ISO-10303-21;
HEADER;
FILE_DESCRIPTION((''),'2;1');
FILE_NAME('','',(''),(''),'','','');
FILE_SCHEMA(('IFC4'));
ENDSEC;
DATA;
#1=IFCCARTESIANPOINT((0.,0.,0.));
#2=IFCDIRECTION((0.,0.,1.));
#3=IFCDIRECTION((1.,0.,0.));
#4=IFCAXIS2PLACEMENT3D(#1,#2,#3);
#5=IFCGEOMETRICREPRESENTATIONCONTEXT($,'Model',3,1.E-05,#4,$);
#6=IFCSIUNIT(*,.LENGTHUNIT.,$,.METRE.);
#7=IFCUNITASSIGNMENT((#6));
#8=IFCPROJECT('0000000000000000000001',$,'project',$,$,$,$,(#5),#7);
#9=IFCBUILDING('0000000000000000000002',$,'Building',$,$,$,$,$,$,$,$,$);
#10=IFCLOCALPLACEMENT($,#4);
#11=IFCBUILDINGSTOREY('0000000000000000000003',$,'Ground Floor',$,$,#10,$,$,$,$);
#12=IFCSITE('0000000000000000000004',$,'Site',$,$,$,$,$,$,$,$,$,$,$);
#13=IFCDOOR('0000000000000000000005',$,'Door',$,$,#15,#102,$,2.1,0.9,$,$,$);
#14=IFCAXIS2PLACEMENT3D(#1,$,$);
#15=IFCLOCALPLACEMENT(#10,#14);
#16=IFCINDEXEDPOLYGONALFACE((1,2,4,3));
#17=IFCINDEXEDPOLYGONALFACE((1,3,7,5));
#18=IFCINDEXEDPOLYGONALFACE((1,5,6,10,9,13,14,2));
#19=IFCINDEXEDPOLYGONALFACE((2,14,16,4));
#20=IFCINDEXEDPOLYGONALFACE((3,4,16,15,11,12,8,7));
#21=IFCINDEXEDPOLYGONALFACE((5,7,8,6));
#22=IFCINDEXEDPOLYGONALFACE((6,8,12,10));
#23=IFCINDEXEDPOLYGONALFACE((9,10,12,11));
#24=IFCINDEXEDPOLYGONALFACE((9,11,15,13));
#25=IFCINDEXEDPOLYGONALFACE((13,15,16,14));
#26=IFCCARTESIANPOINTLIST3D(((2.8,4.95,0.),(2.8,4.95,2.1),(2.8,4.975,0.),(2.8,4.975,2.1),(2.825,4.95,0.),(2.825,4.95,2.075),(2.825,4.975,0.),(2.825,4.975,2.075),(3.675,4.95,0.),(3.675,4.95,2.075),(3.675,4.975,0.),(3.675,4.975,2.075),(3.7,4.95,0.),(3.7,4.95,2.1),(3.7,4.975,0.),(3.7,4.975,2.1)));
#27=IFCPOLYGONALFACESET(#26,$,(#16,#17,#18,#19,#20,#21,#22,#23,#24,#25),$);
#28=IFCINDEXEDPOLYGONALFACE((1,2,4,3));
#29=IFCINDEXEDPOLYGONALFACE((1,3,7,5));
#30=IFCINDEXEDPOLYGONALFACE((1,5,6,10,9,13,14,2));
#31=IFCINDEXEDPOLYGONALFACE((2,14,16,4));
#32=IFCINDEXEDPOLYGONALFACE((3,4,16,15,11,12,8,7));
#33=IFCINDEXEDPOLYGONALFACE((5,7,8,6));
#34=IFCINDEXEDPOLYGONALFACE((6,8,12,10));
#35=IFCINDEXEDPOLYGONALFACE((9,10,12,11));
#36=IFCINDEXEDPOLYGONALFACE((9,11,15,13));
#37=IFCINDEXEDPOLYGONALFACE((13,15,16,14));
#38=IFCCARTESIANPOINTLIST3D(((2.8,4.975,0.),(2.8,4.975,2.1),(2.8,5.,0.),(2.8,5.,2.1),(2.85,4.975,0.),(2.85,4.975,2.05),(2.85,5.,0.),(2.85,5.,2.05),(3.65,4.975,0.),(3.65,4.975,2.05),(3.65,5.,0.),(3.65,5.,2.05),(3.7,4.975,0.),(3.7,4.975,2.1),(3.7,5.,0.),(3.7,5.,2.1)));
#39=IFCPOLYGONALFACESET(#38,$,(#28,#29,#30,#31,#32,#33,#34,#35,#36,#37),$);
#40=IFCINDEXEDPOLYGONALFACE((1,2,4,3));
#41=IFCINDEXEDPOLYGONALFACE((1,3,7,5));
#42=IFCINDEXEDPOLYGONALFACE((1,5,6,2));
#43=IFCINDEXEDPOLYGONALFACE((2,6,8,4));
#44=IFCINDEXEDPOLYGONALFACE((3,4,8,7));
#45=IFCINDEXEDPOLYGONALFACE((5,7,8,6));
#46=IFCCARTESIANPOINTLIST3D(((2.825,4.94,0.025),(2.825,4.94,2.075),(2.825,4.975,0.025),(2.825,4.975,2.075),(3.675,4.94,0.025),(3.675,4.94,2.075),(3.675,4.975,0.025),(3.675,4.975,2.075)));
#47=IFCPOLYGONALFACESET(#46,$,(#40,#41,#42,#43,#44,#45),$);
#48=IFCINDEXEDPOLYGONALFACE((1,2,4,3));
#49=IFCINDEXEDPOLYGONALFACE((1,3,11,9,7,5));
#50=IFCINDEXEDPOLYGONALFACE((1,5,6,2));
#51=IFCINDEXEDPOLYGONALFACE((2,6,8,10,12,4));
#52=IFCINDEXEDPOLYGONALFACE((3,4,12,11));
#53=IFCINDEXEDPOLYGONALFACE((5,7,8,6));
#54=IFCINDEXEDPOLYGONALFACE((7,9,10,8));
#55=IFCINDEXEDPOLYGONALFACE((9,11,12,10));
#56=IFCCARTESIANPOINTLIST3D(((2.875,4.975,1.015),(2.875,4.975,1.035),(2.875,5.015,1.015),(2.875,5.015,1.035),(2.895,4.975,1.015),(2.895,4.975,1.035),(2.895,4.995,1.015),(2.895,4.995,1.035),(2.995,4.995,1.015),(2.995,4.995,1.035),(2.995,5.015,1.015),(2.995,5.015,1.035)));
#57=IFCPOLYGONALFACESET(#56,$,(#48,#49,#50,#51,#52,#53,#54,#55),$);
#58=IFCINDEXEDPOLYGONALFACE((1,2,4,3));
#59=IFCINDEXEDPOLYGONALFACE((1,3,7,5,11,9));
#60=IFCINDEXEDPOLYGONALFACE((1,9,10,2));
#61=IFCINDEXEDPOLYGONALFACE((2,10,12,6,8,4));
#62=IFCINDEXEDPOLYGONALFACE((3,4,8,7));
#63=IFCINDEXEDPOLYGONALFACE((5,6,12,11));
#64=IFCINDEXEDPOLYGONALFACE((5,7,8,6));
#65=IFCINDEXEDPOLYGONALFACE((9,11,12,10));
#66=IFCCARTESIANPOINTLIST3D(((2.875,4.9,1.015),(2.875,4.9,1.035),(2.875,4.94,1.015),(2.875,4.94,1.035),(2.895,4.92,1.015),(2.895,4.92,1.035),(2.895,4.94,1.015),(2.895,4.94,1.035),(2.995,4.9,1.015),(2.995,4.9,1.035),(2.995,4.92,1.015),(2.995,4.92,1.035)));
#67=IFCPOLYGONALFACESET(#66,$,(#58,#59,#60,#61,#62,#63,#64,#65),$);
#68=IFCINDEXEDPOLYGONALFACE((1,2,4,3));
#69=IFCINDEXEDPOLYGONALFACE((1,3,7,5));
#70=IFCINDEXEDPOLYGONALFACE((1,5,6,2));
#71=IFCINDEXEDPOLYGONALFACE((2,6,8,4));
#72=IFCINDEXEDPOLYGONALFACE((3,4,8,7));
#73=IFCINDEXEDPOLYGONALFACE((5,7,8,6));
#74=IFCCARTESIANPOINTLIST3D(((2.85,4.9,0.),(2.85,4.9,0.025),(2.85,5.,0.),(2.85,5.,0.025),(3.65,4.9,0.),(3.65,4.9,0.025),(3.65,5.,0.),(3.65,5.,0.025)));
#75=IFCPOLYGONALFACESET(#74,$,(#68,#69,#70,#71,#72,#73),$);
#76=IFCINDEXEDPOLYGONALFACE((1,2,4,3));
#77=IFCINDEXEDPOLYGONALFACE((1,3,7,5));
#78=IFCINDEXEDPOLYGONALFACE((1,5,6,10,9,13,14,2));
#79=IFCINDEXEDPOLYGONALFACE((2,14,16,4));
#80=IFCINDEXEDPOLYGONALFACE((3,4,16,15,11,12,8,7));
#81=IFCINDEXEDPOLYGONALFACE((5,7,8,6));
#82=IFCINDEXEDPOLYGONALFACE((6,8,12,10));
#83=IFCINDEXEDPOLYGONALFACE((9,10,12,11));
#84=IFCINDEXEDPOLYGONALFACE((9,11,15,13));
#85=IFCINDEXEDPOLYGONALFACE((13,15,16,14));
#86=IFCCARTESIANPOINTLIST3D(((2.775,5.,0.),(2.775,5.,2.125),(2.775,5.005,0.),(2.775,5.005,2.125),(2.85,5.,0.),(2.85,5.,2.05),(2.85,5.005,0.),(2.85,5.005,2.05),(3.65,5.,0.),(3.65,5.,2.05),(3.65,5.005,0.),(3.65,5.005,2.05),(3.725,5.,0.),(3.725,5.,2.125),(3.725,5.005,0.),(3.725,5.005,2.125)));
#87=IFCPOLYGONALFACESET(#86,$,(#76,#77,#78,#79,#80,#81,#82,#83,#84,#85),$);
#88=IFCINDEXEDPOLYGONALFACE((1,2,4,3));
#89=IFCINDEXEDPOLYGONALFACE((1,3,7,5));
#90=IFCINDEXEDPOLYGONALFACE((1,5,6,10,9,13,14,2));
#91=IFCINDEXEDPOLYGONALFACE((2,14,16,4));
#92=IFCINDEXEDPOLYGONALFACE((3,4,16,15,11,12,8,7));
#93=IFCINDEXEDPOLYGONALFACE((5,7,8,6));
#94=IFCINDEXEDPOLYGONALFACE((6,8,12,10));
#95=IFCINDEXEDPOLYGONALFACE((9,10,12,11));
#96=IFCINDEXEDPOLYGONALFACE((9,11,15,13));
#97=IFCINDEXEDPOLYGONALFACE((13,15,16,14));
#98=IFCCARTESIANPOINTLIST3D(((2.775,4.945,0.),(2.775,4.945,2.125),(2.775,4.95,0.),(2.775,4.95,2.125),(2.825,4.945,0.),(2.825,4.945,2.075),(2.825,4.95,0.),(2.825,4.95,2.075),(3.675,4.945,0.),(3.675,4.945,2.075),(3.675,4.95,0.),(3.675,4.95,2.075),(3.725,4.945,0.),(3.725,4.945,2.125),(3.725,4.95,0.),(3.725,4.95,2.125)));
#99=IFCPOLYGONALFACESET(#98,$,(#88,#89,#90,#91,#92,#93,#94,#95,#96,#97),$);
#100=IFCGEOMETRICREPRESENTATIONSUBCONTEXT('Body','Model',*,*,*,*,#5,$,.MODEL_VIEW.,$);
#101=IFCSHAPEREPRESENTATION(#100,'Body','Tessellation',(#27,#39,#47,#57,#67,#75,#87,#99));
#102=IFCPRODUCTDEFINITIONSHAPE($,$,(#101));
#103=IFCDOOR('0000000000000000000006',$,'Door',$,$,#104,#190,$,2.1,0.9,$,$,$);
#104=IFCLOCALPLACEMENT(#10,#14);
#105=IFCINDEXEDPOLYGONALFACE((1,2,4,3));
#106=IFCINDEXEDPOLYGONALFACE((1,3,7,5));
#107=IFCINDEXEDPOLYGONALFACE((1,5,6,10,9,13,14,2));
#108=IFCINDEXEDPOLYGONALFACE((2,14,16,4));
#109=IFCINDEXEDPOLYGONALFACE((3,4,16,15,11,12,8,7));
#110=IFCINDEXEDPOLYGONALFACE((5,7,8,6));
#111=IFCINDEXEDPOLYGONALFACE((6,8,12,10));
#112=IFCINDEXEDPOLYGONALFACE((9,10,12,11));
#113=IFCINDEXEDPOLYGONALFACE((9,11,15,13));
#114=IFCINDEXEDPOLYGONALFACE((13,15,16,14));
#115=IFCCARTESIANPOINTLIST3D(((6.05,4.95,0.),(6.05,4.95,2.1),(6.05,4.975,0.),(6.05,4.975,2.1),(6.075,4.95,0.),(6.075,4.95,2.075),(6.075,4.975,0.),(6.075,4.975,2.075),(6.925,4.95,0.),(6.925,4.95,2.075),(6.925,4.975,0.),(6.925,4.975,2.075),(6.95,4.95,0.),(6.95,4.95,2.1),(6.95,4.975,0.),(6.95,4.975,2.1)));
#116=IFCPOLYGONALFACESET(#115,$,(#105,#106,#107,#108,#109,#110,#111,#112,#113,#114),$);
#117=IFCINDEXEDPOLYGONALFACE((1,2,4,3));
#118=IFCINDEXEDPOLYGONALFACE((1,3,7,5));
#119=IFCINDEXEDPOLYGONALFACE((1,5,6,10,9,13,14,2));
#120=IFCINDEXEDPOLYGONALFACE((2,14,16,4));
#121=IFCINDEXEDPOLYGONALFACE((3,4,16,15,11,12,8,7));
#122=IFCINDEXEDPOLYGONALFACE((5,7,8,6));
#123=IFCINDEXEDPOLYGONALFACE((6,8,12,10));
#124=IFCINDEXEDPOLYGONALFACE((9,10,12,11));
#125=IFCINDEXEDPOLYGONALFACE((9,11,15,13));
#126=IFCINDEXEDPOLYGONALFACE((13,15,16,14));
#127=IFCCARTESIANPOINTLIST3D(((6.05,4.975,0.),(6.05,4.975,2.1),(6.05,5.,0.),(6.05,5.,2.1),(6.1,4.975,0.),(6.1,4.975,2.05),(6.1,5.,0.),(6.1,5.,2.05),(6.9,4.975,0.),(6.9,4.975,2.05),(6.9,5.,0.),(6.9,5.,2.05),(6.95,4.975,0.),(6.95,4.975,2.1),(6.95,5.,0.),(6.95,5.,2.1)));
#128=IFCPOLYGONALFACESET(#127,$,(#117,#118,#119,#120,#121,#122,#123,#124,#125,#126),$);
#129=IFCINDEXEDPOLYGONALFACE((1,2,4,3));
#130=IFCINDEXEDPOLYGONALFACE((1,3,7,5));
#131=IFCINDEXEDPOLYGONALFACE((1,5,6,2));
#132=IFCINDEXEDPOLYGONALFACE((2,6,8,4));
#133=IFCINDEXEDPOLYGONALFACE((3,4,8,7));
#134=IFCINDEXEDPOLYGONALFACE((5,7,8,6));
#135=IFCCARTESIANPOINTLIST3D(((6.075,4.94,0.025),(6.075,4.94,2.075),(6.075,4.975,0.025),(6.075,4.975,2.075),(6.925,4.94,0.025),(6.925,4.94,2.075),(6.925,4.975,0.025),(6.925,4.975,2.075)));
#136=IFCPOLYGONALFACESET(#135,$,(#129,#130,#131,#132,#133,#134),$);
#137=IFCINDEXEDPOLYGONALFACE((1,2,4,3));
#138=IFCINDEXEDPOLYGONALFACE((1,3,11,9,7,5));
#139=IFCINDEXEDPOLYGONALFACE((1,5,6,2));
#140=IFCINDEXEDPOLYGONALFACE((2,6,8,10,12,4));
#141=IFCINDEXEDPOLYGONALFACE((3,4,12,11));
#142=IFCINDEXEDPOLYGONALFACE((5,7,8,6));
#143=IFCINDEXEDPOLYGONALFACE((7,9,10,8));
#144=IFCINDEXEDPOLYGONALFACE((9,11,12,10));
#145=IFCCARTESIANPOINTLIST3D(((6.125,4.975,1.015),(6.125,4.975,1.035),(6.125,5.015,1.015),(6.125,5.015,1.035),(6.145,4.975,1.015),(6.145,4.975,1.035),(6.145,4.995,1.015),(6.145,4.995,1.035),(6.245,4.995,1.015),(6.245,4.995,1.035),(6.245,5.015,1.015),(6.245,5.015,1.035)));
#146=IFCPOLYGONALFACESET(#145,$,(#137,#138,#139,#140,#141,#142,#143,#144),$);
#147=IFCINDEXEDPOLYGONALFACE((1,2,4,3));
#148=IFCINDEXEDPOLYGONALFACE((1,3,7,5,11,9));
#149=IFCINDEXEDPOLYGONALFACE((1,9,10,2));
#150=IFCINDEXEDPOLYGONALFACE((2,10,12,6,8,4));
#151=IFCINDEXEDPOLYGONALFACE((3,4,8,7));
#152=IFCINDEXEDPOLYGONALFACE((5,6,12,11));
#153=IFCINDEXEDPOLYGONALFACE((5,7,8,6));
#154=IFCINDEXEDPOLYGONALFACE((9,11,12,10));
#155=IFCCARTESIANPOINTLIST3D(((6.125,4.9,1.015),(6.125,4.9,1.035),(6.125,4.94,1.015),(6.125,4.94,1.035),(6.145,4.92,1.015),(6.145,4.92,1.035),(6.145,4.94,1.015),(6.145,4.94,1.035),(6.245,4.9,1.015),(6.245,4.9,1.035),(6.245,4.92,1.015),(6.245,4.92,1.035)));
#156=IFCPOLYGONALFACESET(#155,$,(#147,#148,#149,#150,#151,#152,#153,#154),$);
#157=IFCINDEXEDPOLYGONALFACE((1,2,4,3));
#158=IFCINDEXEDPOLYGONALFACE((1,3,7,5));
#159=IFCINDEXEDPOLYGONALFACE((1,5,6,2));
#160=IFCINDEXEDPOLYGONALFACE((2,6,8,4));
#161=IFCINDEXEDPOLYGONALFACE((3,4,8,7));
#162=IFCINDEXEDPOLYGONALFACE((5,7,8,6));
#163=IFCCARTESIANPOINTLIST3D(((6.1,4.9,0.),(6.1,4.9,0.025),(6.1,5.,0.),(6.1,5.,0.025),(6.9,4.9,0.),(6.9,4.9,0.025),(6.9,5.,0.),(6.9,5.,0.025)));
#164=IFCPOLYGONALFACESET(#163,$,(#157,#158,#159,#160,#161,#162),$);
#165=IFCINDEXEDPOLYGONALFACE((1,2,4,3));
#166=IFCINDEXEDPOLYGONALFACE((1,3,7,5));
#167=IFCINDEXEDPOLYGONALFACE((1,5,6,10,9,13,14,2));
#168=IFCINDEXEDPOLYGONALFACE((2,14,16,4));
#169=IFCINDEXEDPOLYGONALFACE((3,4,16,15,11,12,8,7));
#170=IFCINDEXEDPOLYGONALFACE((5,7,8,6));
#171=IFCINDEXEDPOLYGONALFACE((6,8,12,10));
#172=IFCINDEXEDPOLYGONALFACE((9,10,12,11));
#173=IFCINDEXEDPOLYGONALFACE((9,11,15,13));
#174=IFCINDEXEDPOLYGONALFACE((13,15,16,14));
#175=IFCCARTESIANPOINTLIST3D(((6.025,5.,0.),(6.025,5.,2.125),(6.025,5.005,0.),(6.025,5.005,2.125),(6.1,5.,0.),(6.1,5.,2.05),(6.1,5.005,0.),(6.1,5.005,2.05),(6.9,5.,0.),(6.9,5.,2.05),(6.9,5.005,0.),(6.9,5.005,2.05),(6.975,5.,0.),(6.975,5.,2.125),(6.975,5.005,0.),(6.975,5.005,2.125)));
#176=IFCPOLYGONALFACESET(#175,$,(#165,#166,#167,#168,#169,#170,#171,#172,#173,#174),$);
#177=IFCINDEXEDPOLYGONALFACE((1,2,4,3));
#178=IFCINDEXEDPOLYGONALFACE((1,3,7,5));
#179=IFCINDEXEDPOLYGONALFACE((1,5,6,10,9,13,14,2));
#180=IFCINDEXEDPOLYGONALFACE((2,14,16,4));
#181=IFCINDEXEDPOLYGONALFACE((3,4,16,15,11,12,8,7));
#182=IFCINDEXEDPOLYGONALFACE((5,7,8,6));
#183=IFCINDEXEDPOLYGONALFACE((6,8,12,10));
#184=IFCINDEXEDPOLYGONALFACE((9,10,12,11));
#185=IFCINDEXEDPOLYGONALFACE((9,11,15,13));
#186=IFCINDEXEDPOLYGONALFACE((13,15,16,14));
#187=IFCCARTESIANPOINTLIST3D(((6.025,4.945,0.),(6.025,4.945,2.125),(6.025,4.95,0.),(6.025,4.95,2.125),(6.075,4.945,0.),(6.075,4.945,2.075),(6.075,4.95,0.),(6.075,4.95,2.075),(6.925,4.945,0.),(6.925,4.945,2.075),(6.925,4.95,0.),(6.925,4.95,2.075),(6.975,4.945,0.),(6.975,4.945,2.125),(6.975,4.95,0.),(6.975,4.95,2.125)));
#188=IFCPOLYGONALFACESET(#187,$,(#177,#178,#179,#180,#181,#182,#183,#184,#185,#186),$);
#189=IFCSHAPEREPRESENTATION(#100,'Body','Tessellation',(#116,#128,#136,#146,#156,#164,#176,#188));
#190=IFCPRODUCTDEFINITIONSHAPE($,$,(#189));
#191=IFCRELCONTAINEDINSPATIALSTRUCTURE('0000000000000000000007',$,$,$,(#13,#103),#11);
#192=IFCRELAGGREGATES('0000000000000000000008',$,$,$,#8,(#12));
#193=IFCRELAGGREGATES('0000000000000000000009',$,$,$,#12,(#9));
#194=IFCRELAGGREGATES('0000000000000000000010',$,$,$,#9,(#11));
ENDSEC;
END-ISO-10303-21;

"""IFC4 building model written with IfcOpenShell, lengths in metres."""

from ifc_helpers import new_model, si_unit, frame, origin_with_axes, place, context, subcontext, project, spatial, line, indexed_curve, outline, extrude, element, save


model = new_model("IFC4")

# Units and contexts
model_context = context("Model", 3, precision=1e-05, world=origin_with_axes())
body_context = subcontext(model_context, "Body", "Model", "MODEL_VIEW")
ifc_project = project(units=[si_unit("LENGTHUNIT", "METRE")], contexts=[model_context])

# Site, building, storey
site = spatial("IfcSite", under=ifc_project, Name="Site")
building = spatial("IfcBuilding", under=site, Name="Building")
storey_placement = place(None, origin_with_axes())
storey = spatial("IfcBuildingStorey", under=building, at=storey_placement, Name="Ground Floor")

# Doors
door_1_placement = place(storey_placement, frame((3.7, 5.0, 0.0), z_axis=(0.0, 0.0, 1.0), x_axis=(-1.0, 0.0, 0.0)))
element("IfcDoor", 1, at=door_1_placement, inside=storey, Name="Door", OverallHeight=2.1, OverallWidth=0.9, context=body_context, shape_type="SweptSolid", body=[
    extrude(outline(indexed_curve([(0.0, 0.0), (0.0, 2.1), (0.9, 2.1), (0.9, 0.0), (0.875, 0.0), (0.875, 2.075), (0.025, 2.075), (0.025, 0.0)], segments=[line(1, 2, 3, 4, 5, 6, 7, 8, 1)])), frame((0.0, 0.025, 0.0), z_axis=(0.0, -1.0, 0.0), x_axis=(1.0, 0.0, 0.0)), (0.0, 0.0, -1.0), 0.025),
    extrude(outline(indexed_curve([(0.0, 0.0), (0.0, 2.1), (0.9, 2.1), (0.9, 0.0), (0.85, 0.0), (0.85, 2.05), (0.05, 2.05), (0.05, 0.0)], segments=[line(1, 2, 3, 4, 5, 6, 7, 8, 1)])), frame((0.0, 0.0, 0.0), z_axis=(0.0, -1.0, 0.0), x_axis=(1.0, 0.0, 0.0)), (0.0, 0.0, -1.0), 0.025),
    extrude(outline(indexed_curve([(0.0, 0.0), (0.85, 0.0), (0.85, 0.035), (0.0, 0.035)], segments=[line(1, 2, 3, 4, 1)])), frame((0.025, 0.025, 0.025), z_axis=(0.0, 0.0, 1.0), x_axis=(1.0, 0.0, 0.0)), (0.0, 0.0, 1.0), 2.05),
    extrude(outline(indexed_curve([(0.0, 0.0), (0.0, -0.04), (-0.12, -0.04), (-0.12, -0.02), (-0.02, -0.02), (-0.02, 0.0)], segments=[line(1, 2, 3, 4, 5, 6, 1)])), frame((0.825, 0.025, 1.015), z_axis=(0.0, 0.0, 1.0), x_axis=(1.0, 0.0, 0.0)), (0.0, 0.0, 1.0), 0.02),
    extrude(outline(indexed_curve([(0.0, 0.0), (0.0, 0.04), (-0.12, 0.04), (-0.12, 0.02), (-0.02, 0.02), (-0.02, 0.0)], segments=[line(1, 2, 3, 4, 5, 6, 1)])), frame((0.825, 0.06, 1.015), z_axis=(0.0, 0.0, 1.0), x_axis=(1.0, 0.0, 0.0)), (0.0, 0.0, 1.0), 0.02),
    extrude(outline(indexed_curve([(0.0, 0.0), (0.8, 0.0), (0.8, 0.1), (0.0, 0.1)], segments=[line(1, 2, 3, 4, 1)])), frame((0.05, 0.0, 0.0), z_axis=(0.0, 0.0, 1.0), x_axis=(1.0, 0.0, 0.0)), (0.0, 0.0, 1.0), 0.025),
    extrude(outline(indexed_curve([(0.0, 0.0), (0.0, 2.125), (0.95, 2.125), (0.95, 0.0), (0.875, 0.0), (0.875, 2.05), (0.075, 2.05), (0.075, 0.0)], segments=[line(1, 2, 3, 4, 5, 6, 7, 8, 1)])), frame((-0.025, -0.005, 0.0), z_axis=(0.0, -1.0, 0.0), x_axis=(1.0, 0.0, 0.0)), (0.0, 0.0, -1.0), 0.005),
    extrude(outline(indexed_curve([(0.0, 0.0), (0.0, 2.125), (0.95, 2.125), (0.95, 0.0), (0.9, 0.0), (0.9, 2.075), (0.05, 2.075), (0.05, 0.0)], segments=[line(1, 2, 3, 4, 5, 6, 7, 8, 1)])), frame((-0.025, 0.05, 0.0), z_axis=(0.0, -1.0, 0.0), x_axis=(1.0, 0.0, 0.0)), (0.0, 0.0, -1.0), 0.005),
])
door_2_placement = place(storey_placement, frame((6.95, 5.0, 0.0), z_axis=(0.0, 0.0, 1.0), x_axis=(-1.0, 0.0, 0.0)))
element("IfcDoor", 2, at=door_2_placement, inside=storey, Name="Door", OverallHeight=2.1, OverallWidth=0.9, context=body_context, shape_type="SweptSolid", body=[
    extrude(outline(indexed_curve([(0.0, 0.0), (0.0, 2.1), (0.9, 2.1), (0.9, 0.0), (0.875, 0.0), (0.875, 2.075), (0.025, 2.075), (0.025, 0.0)], segments=[line(1, 2, 3, 4, 5, 6, 7, 8, 1)])), frame((0.0, 0.025, 0.0), z_axis=(0.0, -1.0, 0.0), x_axis=(1.0, 0.0, 0.0)), (0.0, 0.0, -1.0), 0.025),
    extrude(outline(indexed_curve([(0.0, 0.0), (0.0, 2.1), (0.9, 2.1), (0.9, 0.0), (0.85, 0.0), (0.85, 2.05), (0.05, 2.05), (0.05, 0.0)], segments=[line(1, 2, 3, 4, 5, 6, 7, 8, 1)])), frame((0.0, 0.0, 0.0), z_axis=(0.0, -1.0, 0.0), x_axis=(1.0, 0.0, 0.0)), (0.0, 0.0, -1.0), 0.025),
    extrude(outline(indexed_curve([(0.0, 0.0), (0.85, 0.0), (0.85, 0.035), (0.0, 0.035)], segments=[line(1, 2, 3, 4, 1)])), frame((0.025, 0.025, 0.025), z_axis=(0.0, 0.0, 1.0), x_axis=(1.0, 0.0, 0.0)), (0.0, 0.0, 1.0), 2.05),
    extrude(outline(indexed_curve([(0.0, 0.0), (0.0, -0.04), (-0.12, -0.04), (-0.12, -0.02), (-0.02, -0.02), (-0.02, 0.0)], segments=[line(1, 2, 3, 4, 5, 6, 1)])), frame((0.825, 0.025, 1.015), z_axis=(0.0, 0.0, 1.0), x_axis=(1.0, 0.0, 0.0)), (0.0, 0.0, 1.0), 0.02),
    extrude(outline(indexed_curve([(0.0, 0.0), (0.0, 0.04), (-0.12, 0.04), (-0.12, 0.02), (-0.02, 0.02), (-0.02, 0.0)], segments=[line(1, 2, 3, 4, 5, 6, 1)])), frame((0.825, 0.06, 1.015), z_axis=(0.0, 0.0, 1.0), x_axis=(1.0, 0.0, 0.0)), (0.0, 0.0, 1.0), 0.02),
    extrude(outline(indexed_curve([(0.0, 0.0), (0.8, 0.0), (0.8, 0.1), (0.0, 0.1)], segments=[line(1, 2, 3, 4, 1)])), frame((0.05, 0.0, 0.0), z_axis=(0.0, 0.0, 1.0), x_axis=(1.0, 0.0, 0.0)), (0.0, 0.0, 1.0), 0.025),
    extrude(outline(indexed_curve([(0.0, 0.0), (0.0, 2.125), (0.95, 2.125), (0.95, 0.0), (0.875, 0.0), (0.875, 2.05), (0.075, 2.05), (0.075, 0.0)], segments=[line(1, 2, 3, 4, 5, 6, 7, 8, 1)])), frame((-0.025, -0.005, 0.0), z_axis=(0.0, -1.0, 0.0), x_axis=(1.0, 0.0, 0.0)), (0.0, 0.0, -1.0), 0.005),
    extrude(outline(indexed_curve([(0.0, 0.0), (0.0, 2.125), (0.95, 2.125), (0.95, 0.0), (0.9, 0.0), (0.9, 2.075), (0.05, 2.075), (0.05, 0.0)], segments=[line(1, 2, 3, 4, 5, 6, 7, 8, 1)])), frame((-0.025, 0.05, 0.0), z_axis=(0.0, -1.0, 0.0), x_axis=(1.0, 0.0, 0.0)), (0.0, 0.0, -1.0), 0.005),
])

save(model, "model.ifc")
